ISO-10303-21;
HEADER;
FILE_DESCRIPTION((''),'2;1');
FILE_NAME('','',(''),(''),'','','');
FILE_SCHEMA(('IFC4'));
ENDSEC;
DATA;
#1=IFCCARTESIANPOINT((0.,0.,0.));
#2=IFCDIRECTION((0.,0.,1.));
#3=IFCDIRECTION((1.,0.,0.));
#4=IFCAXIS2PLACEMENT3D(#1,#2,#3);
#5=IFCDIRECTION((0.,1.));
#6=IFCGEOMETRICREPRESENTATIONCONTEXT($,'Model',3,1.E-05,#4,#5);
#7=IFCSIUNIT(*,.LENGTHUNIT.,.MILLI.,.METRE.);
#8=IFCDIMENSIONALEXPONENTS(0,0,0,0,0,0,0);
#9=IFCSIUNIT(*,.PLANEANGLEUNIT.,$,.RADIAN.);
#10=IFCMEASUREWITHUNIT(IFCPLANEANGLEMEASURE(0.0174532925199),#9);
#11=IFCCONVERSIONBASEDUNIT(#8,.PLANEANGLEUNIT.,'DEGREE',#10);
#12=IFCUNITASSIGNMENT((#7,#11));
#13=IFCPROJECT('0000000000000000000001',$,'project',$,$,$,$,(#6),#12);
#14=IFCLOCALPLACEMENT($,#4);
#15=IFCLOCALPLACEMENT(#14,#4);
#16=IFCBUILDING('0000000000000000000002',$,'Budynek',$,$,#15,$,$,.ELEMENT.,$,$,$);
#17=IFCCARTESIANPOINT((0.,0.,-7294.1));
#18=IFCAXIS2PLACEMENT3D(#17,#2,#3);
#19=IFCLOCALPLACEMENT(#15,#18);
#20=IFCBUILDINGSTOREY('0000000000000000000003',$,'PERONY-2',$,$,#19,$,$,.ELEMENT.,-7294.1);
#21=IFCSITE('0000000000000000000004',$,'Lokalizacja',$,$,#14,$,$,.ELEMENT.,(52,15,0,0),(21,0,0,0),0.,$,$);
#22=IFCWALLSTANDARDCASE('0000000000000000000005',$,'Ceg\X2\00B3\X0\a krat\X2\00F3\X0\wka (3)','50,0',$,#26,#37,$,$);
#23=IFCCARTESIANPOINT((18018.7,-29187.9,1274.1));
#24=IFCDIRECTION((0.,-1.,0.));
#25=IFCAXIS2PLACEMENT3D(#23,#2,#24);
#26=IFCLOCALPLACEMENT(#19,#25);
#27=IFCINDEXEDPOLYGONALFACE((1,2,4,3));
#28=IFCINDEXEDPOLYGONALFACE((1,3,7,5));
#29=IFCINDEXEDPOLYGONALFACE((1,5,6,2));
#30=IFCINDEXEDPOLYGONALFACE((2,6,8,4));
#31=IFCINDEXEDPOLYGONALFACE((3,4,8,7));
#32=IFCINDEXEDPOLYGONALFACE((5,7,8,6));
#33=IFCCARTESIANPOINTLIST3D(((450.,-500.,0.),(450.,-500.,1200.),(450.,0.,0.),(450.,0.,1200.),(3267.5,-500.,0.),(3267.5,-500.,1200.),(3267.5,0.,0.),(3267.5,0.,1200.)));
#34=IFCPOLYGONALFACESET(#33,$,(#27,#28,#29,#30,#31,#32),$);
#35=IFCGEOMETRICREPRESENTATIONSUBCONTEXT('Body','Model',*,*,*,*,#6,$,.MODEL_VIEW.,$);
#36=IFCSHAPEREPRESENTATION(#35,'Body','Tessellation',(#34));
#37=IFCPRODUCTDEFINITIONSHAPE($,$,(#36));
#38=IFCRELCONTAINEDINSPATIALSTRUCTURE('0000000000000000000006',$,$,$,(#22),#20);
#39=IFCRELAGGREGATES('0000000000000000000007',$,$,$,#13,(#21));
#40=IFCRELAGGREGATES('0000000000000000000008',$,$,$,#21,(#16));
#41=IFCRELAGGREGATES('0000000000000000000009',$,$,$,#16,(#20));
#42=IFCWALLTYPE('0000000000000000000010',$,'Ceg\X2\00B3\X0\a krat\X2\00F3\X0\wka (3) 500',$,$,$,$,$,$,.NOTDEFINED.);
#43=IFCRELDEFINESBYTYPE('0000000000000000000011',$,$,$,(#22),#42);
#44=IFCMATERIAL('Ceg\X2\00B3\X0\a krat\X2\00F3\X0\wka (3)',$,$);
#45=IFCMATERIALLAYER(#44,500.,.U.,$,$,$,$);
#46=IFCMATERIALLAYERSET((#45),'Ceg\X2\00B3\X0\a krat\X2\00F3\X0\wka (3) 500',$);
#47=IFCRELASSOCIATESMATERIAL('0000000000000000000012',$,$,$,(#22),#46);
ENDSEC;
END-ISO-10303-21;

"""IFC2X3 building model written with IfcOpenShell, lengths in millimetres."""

from ifc_helpers import new_model, entity, si_unit, converted_unit, direction, frame, origin_with_axes, place, context, subcontext, project, spatial, polyline, outline, extrude, material, layer, layer_set, layer_usage, type_object, element, save


model = new_model("IFC2X3")

# Units and contexts
model_context = context("Model", 3, precision=1e-05, world=origin_with_axes(), true_north=direction((0.0, 1.0)))
body_context = subcontext(model_context, "Body", "Model", "MODEL_VIEW")
ifc_project = project(units=[si_unit("LENGTHUNIT", "METRE", prefix="MILLI"), converted_unit("PLANEANGLEUNIT", "DEGREE", entity("IfcPlaneAngleMeasure", 0.0174532925199), si_unit("PLANEANGLEUNIT", "RADIAN"), dimensions=[0, 0, 0, 0, 0, 0, 0])], contexts=[model_context])

# Site, building, storey
site_placement = place(None, origin_with_axes())
site = spatial("IfcSite", under=ifc_project, at=site_placement, Name="Lokalizacja", CompositionType="ELEMENT", RefLatitude=(52, 15, 0, 0), RefLongitude=(21, 0, 0, 0), RefElevation=0.0)
building_placement = place(site_placement, origin_with_axes())
building = spatial("IfcBuilding", under=site, at=building_placement, Name="Budynek", CompositionType="ELEMENT")
storey_placement = place(building_placement, frame((0.0, 0.0, -7294.1), z_axis=(0.0, 0.0, 1.0), x_axis=(1.0, 0.0, 0.0)))
storey = spatial("IfcBuildingStorey", under=building, at=storey_placement, Name="PERONY-2", CompositionType="ELEMENT", Elevation=-7294.1)

# Wall
ifc_material_1 = material(Name="Ceg³a kratówka (3)")
ifc_layer_1 = layer(ifc_material_1, 500.0, ventilated="UNKNOWN")
ifc_layer_set_1 = layer_set([ifc_layer_1], Name="Ceg³a kratówka (3) 500")
wall_type_1 = type_object("IfcWallType", Name="Ceg³a kratówka (3) 500", PredefinedType="NOTDEFINED")
ifc_layer_usage_1 = layer_usage(ifc_layer_set_1, "AXIS2", "NEGATIVE", 0.0)
wall_1_placement = place(storey_placement, frame((18018.7, -29187.9, 1274.1), z_axis=(0.0, 0.0, 1.0), x_axis=(0.0, -1.0, 0.0)))
element("IfcWallStandardCase", 1, at=wall_1_placement, inside=storey, type_object=wall_type_1, material=ifc_layer_usage_1, Name="Ceg³a kratówka (3)", Description="50,0", context=body_context, shape_type="SweptSolid", body=[
    extrude(outline(polyline([(450.0, -500.0), (3267.5, -500.0), (3267.5, 0.0), (450.0, 0.0), (450.0, -500.0)])), origin_with_axes(), (0.0, 0.0, 1.0), 1200.0),
])

save(model, "model.ifc")
